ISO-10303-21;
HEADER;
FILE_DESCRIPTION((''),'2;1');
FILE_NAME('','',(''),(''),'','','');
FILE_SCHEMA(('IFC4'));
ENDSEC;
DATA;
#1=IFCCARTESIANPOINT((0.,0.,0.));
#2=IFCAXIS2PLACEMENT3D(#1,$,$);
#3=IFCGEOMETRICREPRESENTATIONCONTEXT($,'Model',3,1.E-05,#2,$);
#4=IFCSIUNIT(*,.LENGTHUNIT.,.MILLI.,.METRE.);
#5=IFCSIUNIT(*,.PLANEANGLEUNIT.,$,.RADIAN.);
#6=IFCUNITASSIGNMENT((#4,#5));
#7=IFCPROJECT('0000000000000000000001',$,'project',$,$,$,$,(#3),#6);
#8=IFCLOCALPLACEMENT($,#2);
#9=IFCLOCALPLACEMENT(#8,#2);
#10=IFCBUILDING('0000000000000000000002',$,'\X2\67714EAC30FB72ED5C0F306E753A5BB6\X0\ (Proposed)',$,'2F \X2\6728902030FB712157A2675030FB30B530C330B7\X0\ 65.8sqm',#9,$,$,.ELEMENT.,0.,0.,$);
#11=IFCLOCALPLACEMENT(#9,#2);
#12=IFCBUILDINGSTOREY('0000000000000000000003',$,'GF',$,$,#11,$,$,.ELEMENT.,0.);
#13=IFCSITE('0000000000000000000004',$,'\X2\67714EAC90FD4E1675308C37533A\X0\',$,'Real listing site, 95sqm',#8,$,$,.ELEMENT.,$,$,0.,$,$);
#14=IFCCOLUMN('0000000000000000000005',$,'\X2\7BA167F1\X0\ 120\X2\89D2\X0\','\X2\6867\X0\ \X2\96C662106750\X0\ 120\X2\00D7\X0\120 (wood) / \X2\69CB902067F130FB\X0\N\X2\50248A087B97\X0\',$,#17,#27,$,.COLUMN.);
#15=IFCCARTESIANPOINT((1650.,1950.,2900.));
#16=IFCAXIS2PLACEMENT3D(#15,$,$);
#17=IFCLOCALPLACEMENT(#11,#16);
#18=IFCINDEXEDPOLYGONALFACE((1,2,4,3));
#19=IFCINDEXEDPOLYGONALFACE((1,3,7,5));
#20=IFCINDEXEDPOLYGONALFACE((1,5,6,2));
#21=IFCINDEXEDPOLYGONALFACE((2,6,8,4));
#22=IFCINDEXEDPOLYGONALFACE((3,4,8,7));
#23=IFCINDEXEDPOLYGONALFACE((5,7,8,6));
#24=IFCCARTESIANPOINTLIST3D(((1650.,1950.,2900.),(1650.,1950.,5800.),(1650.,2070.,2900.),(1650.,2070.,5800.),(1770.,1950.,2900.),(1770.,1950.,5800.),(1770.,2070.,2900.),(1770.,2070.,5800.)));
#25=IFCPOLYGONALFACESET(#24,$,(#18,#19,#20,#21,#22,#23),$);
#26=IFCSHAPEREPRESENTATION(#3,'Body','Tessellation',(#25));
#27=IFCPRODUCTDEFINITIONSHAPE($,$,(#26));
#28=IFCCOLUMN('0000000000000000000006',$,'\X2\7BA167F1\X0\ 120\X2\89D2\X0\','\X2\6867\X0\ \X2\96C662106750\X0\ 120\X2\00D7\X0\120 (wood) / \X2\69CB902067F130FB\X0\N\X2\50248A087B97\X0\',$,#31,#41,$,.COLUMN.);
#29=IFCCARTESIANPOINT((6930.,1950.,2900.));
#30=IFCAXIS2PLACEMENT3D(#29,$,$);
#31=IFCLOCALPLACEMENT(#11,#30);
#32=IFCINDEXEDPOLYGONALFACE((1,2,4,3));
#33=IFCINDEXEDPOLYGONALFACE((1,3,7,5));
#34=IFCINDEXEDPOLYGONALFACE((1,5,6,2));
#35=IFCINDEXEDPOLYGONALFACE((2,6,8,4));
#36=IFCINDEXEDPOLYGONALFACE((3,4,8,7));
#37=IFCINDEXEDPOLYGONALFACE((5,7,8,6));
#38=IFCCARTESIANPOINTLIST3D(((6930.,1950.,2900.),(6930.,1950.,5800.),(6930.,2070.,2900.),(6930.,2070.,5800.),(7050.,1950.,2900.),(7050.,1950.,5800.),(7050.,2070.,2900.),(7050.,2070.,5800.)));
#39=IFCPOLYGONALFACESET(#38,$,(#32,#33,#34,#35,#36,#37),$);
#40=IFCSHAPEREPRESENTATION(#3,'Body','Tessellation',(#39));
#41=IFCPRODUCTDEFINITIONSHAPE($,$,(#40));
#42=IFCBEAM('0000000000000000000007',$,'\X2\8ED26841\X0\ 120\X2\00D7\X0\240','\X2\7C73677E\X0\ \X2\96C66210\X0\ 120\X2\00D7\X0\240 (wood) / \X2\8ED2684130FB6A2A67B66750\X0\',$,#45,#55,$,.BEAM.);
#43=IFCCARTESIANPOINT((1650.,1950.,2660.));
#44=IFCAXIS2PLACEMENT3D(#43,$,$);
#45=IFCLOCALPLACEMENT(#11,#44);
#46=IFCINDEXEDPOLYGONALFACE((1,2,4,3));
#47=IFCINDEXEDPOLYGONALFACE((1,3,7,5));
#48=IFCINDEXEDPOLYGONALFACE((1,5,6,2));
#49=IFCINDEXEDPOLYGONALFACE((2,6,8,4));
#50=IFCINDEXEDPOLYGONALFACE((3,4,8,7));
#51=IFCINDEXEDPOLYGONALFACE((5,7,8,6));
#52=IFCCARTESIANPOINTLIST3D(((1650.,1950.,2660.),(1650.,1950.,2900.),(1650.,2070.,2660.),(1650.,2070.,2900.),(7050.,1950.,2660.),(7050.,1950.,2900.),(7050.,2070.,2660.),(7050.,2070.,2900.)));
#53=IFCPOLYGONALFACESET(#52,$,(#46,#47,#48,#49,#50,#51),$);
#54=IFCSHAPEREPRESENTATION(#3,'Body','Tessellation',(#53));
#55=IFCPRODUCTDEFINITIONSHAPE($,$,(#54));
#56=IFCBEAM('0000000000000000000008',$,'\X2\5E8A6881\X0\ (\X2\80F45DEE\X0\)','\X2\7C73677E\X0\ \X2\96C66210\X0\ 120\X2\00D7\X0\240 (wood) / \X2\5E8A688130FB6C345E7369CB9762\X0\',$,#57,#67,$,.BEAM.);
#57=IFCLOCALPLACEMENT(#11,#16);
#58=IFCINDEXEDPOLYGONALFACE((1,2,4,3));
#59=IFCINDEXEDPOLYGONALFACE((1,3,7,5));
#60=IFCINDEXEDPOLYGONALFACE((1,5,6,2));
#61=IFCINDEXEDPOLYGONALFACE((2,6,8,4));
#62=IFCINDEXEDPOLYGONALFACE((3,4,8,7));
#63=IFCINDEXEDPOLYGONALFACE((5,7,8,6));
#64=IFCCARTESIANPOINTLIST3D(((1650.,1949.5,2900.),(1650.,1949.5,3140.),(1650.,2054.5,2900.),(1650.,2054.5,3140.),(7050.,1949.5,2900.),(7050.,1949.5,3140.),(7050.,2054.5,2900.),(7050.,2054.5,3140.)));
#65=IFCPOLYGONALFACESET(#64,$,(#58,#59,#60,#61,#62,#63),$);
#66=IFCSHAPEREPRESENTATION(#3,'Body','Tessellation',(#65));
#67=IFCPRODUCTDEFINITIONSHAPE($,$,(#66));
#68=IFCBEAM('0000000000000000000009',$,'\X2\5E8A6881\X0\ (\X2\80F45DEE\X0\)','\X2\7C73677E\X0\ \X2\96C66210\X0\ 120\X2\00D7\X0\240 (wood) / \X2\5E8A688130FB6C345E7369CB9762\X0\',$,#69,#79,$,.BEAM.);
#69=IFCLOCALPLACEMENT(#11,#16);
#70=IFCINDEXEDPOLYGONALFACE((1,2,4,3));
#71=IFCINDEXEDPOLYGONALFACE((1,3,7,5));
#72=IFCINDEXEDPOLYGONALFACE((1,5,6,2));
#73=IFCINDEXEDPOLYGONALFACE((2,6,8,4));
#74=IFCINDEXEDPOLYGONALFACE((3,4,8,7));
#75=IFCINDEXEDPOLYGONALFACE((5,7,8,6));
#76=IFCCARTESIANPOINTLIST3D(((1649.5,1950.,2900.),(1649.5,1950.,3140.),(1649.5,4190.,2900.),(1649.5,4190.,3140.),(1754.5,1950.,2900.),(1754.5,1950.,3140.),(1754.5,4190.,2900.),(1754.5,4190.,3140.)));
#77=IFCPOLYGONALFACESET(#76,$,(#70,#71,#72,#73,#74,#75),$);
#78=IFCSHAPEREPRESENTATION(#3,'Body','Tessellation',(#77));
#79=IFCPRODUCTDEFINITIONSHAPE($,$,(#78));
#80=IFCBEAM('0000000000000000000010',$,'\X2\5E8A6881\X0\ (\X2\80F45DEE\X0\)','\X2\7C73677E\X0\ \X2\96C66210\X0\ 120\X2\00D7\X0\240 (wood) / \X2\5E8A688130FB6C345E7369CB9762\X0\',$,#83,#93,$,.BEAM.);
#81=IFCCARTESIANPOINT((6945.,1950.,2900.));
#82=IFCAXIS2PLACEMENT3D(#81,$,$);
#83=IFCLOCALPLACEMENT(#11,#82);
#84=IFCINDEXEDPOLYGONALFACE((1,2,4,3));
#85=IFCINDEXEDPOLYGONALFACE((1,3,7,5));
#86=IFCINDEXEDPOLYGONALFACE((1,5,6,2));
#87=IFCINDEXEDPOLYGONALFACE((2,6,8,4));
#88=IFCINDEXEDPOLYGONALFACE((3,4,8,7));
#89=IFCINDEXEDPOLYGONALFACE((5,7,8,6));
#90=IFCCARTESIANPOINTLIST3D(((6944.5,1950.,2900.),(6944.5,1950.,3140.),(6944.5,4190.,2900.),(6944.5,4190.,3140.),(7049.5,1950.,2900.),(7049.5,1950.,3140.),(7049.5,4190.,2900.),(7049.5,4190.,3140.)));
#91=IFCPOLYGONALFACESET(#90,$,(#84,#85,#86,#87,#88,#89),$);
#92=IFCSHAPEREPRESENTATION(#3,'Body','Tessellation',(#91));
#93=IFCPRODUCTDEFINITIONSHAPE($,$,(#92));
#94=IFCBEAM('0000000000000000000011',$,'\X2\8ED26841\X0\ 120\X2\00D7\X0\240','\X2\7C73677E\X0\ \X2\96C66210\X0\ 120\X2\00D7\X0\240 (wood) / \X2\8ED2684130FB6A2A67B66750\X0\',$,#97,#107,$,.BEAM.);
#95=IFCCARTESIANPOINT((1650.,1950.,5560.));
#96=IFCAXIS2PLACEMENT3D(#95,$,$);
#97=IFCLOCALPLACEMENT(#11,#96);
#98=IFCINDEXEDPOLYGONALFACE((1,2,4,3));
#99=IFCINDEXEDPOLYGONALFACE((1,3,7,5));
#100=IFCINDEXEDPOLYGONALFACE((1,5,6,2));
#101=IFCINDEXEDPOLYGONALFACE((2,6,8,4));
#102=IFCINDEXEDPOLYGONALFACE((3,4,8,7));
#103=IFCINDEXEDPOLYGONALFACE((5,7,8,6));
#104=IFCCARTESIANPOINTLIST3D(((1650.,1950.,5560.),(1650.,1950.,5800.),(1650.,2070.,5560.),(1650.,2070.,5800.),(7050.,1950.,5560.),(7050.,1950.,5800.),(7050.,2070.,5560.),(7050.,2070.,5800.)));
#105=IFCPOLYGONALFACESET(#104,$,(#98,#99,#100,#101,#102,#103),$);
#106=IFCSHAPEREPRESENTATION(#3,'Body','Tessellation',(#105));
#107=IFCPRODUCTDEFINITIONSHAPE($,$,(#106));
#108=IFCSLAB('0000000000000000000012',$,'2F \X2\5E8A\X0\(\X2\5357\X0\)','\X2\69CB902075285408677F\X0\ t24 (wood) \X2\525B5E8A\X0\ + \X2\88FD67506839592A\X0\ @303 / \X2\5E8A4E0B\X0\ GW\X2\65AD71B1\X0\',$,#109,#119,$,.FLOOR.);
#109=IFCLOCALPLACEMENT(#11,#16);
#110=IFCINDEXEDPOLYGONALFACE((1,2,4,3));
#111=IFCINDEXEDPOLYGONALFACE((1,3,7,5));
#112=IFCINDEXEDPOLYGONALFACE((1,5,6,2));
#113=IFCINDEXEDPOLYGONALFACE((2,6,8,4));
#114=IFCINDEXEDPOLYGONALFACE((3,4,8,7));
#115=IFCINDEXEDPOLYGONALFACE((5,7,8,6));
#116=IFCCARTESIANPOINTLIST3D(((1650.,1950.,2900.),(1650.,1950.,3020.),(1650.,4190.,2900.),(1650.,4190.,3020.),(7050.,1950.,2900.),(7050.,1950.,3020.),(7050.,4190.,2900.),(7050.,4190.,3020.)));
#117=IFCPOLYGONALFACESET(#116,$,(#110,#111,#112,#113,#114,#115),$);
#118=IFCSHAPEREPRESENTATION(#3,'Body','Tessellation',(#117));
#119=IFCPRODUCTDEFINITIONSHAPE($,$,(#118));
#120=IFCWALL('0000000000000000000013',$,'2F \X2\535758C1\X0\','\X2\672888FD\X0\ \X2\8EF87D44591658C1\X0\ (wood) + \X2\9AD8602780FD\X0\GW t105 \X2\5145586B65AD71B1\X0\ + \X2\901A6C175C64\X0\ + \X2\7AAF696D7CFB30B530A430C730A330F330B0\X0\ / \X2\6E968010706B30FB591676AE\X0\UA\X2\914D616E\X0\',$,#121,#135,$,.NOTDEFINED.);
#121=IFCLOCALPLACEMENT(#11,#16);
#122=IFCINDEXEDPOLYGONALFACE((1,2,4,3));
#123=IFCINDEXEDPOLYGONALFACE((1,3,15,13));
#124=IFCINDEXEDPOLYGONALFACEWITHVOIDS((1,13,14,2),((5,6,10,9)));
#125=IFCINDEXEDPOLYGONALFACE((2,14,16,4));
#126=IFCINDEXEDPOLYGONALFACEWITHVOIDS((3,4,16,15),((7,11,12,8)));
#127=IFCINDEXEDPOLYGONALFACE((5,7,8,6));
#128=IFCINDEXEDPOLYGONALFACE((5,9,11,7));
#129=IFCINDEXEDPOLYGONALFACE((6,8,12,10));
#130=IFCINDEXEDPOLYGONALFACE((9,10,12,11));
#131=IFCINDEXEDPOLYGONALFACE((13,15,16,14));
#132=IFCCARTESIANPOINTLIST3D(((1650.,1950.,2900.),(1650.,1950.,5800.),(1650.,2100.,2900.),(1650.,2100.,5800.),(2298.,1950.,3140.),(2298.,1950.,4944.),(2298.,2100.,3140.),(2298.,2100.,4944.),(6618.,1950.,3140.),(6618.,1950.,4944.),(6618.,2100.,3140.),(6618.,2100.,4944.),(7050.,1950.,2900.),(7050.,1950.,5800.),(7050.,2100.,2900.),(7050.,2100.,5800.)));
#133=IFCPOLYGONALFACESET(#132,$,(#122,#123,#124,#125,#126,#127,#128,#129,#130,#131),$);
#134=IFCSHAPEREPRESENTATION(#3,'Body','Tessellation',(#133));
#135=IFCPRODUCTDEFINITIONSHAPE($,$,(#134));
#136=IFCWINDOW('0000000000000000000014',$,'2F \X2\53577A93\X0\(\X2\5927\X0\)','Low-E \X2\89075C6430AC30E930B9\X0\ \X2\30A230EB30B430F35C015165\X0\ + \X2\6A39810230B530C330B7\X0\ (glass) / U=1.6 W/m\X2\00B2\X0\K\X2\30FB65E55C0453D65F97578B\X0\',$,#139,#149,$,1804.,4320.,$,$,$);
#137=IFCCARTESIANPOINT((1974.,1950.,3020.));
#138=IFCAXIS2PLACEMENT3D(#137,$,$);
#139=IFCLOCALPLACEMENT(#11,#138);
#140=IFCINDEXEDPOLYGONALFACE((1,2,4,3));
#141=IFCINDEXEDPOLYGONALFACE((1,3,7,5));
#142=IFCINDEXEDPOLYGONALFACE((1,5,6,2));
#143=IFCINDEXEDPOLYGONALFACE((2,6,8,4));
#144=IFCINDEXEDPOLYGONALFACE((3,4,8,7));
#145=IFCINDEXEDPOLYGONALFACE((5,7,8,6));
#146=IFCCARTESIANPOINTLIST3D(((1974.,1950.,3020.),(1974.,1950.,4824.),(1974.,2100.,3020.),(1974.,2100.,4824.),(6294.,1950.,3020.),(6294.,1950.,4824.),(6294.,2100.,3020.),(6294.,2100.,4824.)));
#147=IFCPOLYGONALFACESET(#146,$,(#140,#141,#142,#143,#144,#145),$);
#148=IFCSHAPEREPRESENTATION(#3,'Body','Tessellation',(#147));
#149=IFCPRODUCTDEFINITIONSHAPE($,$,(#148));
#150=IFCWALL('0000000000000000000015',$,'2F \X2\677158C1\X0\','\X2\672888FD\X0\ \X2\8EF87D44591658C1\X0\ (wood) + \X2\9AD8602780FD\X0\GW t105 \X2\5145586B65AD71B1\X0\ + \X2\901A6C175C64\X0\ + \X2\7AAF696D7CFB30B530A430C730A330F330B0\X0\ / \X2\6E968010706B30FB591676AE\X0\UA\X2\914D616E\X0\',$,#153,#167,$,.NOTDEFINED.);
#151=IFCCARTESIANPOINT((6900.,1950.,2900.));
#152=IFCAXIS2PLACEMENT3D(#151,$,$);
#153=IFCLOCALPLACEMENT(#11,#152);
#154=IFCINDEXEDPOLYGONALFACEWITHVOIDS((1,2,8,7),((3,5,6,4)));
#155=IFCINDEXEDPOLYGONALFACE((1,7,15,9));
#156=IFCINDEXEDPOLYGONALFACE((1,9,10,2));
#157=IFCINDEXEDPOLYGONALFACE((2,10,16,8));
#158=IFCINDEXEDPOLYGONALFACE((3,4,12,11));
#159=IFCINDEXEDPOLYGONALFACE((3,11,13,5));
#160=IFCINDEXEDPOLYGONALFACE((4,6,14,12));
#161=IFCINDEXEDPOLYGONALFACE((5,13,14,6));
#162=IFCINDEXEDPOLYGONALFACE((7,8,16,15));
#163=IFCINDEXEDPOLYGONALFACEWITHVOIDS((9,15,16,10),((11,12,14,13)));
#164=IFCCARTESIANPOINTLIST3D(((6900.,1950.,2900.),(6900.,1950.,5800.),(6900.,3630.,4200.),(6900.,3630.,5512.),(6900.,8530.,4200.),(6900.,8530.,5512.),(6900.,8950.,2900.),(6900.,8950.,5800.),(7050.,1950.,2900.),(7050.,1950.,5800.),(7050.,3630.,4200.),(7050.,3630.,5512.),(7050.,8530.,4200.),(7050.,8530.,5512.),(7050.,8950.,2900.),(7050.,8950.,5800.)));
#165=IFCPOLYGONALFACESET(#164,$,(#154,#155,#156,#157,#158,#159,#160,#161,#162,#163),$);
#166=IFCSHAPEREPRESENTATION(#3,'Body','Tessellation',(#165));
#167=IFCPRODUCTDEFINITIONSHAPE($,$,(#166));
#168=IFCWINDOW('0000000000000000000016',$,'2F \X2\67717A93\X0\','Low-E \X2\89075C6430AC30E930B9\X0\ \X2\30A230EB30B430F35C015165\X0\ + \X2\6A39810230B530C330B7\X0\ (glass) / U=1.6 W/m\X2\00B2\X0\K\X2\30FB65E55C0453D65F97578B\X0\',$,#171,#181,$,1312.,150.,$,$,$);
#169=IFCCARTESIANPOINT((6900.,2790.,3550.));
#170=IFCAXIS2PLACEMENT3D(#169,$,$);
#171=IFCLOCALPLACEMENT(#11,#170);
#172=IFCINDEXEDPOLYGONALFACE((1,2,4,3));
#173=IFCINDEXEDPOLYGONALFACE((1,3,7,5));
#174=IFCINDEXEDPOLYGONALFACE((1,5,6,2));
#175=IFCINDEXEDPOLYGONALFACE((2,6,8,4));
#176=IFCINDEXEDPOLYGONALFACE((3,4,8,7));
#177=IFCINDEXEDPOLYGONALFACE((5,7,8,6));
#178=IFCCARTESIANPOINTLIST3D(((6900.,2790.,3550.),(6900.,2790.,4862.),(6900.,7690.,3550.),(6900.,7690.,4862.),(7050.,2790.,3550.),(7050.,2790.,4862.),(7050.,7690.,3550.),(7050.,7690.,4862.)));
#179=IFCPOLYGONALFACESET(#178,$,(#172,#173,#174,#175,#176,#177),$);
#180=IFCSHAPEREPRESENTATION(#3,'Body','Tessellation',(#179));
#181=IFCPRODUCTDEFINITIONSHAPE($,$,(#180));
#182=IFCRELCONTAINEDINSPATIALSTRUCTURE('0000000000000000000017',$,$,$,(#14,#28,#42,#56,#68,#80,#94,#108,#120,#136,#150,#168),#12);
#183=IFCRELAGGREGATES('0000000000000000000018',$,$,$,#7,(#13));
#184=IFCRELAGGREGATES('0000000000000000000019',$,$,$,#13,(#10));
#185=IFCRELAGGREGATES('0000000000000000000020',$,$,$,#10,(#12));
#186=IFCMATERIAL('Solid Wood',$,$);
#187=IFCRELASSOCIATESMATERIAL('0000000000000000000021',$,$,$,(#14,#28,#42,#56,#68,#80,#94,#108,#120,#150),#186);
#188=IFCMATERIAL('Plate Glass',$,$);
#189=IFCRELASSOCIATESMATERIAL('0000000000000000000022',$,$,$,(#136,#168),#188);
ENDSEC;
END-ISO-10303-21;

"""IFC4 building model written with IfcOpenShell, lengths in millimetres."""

from ifc_helpers import new_model, si_unit, frame, frame_2d, origin, place, context, project, spatial, rectangle, extrude, material, element, fill, save


model = new_model("IFC4")

# Units and contexts
model_context = context("Model", 3, precision=1e-05, world=origin())
ifc_project = project(units=[si_unit("LENGTHUNIT", "METRE", prefix="MILLI"), si_unit("PLANEANGLEUNIT", "RADIAN")], contexts=[model_context])

# Site, building, storey
site_placement = place(None, origin())
site = spatial("IfcSite", under=ifc_project, at=site_placement, Name="東京都世田谷区", ObjectType="Real listing site, 95sqm", CompositionType="ELEMENT", RefElevation=0.0)
building_placement = place(site_placement, origin())
building = spatial("IfcBuilding", under=site, at=building_placement, Name="東京・狭小の町家 (Proposed)", ObjectType="2F 木造・無垢材・サッシ 65.8sqm", CompositionType="ELEMENT", ElevationOfRefHeight=0.0, ElevationOfTerrain=0.0)
storey_placement = place(building_placement, origin())
storey = spatial("IfcBuildingStorey", under=building, at=storey_placement, Name="GF", CompositionType="ELEMENT", Elevation=0.0)

# Columns
ifc_material_1 = material(Name="Solid Wood")
column_1_placement = place(storey_placement, frame((1650.0, 1950.0, 2900.0)))
element("IfcColumn", 1, at=column_1_placement, inside=storey, material=ifc_material_1, Name="管柱 120角", Description="桧 集成材 120×120 (wood) / 構造柱・N値計算", PredefinedType="COLUMN", context=model_context, shape_type="SweptSolid", body=[
    extrude(rectangle(XDim=120.0, YDim=120.0, at=frame_2d((60.0, 60.0))), frame((1650.0, 1950.0, 2900.0)), (0.0, 0.0, 1.0), 2900.0),
])
column_2_placement = place(storey_placement, frame((6930.0, 1950.0, 2900.0)))
element("IfcColumn", 2, at=column_2_placement, inside=storey, material=ifc_material_1, Name="管柱 120角", Description="桧 集成材 120×120 (wood) / 構造柱・N値計算", PredefinedType="COLUMN", context=model_context, shape_type="SweptSolid", body=[
    extrude(rectangle(XDim=120.0, YDim=120.0, at=frame_2d((60.0, 60.0))), frame((6930.0, 1950.0, 2900.0)), (0.0, 0.0, 1.0), 2900.0),
])

# Beams
beam_1_placement = place(storey_placement, frame((1650.0, 1950.0, 2660.0)))
element("IfcBeam", 3, at=beam_1_placement, inside=storey, material=ifc_material_1, Name="軒桁 120×240", Description="米松 集成 120×240 (wood) / 軒桁・横架材", PredefinedType="BEAM", context=model_context, shape_type="SweptSolid", body=[
    extrude(rectangle(XDim=5400.0, YDim=120.0, at=frame_2d((2700.0, 60.0))), frame((1650.0, 1950.0, 2660.0)), (0.0, 0.0, 1.0), 240.0),
])
beam_2_placement = place(storey_placement, frame((1650.0, 1950.0, 2900.0)))
element("IfcBeam", 4, at=beam_2_placement, inside=storey, material=ifc_material_1, Name="床梁 (胴差)", Description="米松 集成 120×240 (wood) / 床梁・水平構面", PredefinedType="BEAM", context=model_context, shape_type="SweptSolid", body=[
    extrude(rectangle(XDim=5400.0, YDim=105.0, at=frame_2d((2700.0, 52.0))), frame((1650.0, 1950.0, 2900.0)), (0.0, 0.0, 1.0), 240.0),
])
beam_3_placement = place(storey_placement, frame((1650.0, 1950.0, 2900.0)))
element("IfcBeam", 5, at=beam_3_placement, inside=storey, material=ifc_material_1, Name="床梁 (胴差)", Description="米松 集成 120×240 (wood) / 床梁・水平構面", PredefinedType="BEAM", context=model_context, shape_type="SweptSolid", body=[
    extrude(rectangle(XDim=105.0, YDim=2240.0, at=frame_2d((52.0, 1120.0))), frame((1650.0, 1950.0, 2900.0)), (0.0, 0.0, 1.0), 240.0),
])
beam_4_placement = place(storey_placement, frame((6945.0, 1950.0, 2900.0)))
element("IfcBeam", 6, at=beam_4_placement, inside=storey, material=ifc_material_1, Name="床梁 (胴差)", Description="米松 集成 120×240 (wood) / 床梁・水平構面", PredefinedType="BEAM", context=model_context, shape_type="SweptSolid", body=[
    extrude(rectangle(XDim=105.0, YDim=2240.0, at=frame_2d((52.0, 1120.0))), frame((6945.0, 1950.0, 2900.0)), (0.0, 0.0, 1.0), 240.0),
])
beam_5_placement = place(storey_placement, frame((1650.0, 1950.0, 5560.0)))
element("IfcBeam", 7, at=beam_5_placement, inside=storey, material=ifc_material_1, Name="軒桁 120×240", Description="米松 集成 120×240 (wood) / 軒桁・横架材", PredefinedType="BEAM", context=model_context, shape_type="SweptSolid", body=[
    extrude(rectangle(XDim=5400.0, YDim=120.0, at=frame_2d((2700.0, 60.0))), frame((1650.0, 1950.0, 5560.0)), (0.0, 0.0, 1.0), 240.0),
])

# Slab
slab_placement = place(storey_placement, frame((1650.0, 1950.0, 2900.0)))
element("IfcSlab", 8, at=slab_placement, inside=storey, material=ifc_material_1, Name="2F 床(南)", Description="構造用合板 t24 (wood) 剛床 + 製材根太 @303 / 床下 GW断熱", PredefinedType="FLOOR", context=model_context, shape_type="SweptSolid", body=[
    extrude(rectangle(XDim=5400.0, YDim=2240.0, at=frame_2d((2700.0, 1120.0))), frame((1650.0, 1950.0, 2900.0)), (0.0, 0.0, 1.0), 120.0),
])

# Walls, openings, windows
wall_1_placement = place(storey_placement, frame((1650.0, 1950.0, 2900.0)))
wall_1 = element("IfcWall", 9, at=wall_1_placement, inside=storey, material=ifc_material_1, Name="2F 南壁", Description="木製 軸組外壁 (wood) + 高性能GW t105 充填断熱 + 通気層 + 窯業系サイディング / 準耐火・外皮UA配慮", PredefinedType="NOTDEFINED", context=model_context, shape_type="SweptSolid", body=[
    extrude(rectangle(XDim=5400.0, YDim=150.0, at=frame_2d((2700.0, 75.0))), frame((1650.0, 1950.0, 2900.0)), (0.0, 0.0, 1.0), 2900.0),
])
opening_1_placement = place(storey_placement, frame((1974.0, 1950.0, 3020.0)))
opening_1 = element("IfcOpeningElement", 10, at=opening_1_placement, cuts=wall_1, PredefinedType="NOTDEFINED", context=model_context, shape_type="SweptSolid", body=[
    extrude(rectangle(XDim=4320.0, YDim=150.0, at=frame_2d((2160.0, 75.0))), frame((1974.0, 1950.0, 3020.0)), (0.0, 0.0, 1.0), 1804.0),
])
ifc_material_2 = material(Name="Plate Glass")
window_1_placement = place(storey_placement, frame((1974.0, 1950.0, 3020.0)))
window_1 = element("IfcWindow", 11, at=window_1_placement, inside=storey, material=ifc_material_2, Name="2F 南窓(大)", Description="Low-E 複層ガラス アルゴン封入 + 樹脂サッシ (glass) / U=1.6 W/m²K・日射取得型", OverallHeight=1804.0, OverallWidth=4320.0, context=model_context, shape_type="SweptSolid", body=[
    extrude(rectangle(XDim=4320.0, YDim=150.0, at=frame_2d((2160.0, 75.0))), frame((1974.0, 1950.0, 3020.0)), (0.0, 0.0, 1.0), 1804.0),
])
fill(opening_1, window_1)
wall_2_placement = place(storey_placement, frame((6900.0, 1950.0, 2900.0)))
wall_2 = element("IfcWall", 12, at=wall_2_placement, inside=storey, material=ifc_material_1, Name="2F 東壁", Description="木製 軸組外壁 (wood) + 高性能GW t105 充填断熱 + 通気層 + 窯業系サイディング / 準耐火・外皮UA配慮", PredefinedType="NOTDEFINED", context=model_context, shape_type="SweptSolid", body=[
    extrude(rectangle(XDim=150.0, YDim=7000.0, at=frame_2d((75.0, 3500.0))), frame((6900.0, 1950.0, 2900.0)), (0.0, 0.0, 1.0), 2900.0),
])
opening_2_placement = place(storey_placement, frame((6900.0, 2790.0, 3550.0)))
opening_2 = element("IfcOpeningElement", 13, at=opening_2_placement, cuts=wall_2, PredefinedType="NOTDEFINED", context=model_context, shape_type="SweptSolid", body=[
    extrude(rectangle(XDim=150.0, YDim=4900.0, at=frame_2d((75.0, 2450.0))), frame((6900.0, 2790.0, 3550.0)), (0.0, 0.0, 1.0), 1312.0),
])
window_2_placement = place(storey_placement, frame((6900.0, 2790.0, 3550.0)))
window_2 = element("IfcWindow", 14, at=window_2_placement, inside=storey, material=ifc_material_2, Name="2F 東窓", Description="Low-E 複層ガラス アルゴン封入 + 樹脂サッシ (glass) / U=1.6 W/m²K・日射取得型", OverallHeight=1312.0, OverallWidth=150.0, context=model_context, shape_type="SweptSolid", body=[
    extrude(rectangle(XDim=150.0, YDim=4900.0, at=frame_2d((75.0, 2450.0))), frame((6900.0, 2790.0, 3550.0)), (0.0, 0.0, 1.0), 1312.0),
])
fill(opening_2, window_2)

save(model, "model.ifc")
